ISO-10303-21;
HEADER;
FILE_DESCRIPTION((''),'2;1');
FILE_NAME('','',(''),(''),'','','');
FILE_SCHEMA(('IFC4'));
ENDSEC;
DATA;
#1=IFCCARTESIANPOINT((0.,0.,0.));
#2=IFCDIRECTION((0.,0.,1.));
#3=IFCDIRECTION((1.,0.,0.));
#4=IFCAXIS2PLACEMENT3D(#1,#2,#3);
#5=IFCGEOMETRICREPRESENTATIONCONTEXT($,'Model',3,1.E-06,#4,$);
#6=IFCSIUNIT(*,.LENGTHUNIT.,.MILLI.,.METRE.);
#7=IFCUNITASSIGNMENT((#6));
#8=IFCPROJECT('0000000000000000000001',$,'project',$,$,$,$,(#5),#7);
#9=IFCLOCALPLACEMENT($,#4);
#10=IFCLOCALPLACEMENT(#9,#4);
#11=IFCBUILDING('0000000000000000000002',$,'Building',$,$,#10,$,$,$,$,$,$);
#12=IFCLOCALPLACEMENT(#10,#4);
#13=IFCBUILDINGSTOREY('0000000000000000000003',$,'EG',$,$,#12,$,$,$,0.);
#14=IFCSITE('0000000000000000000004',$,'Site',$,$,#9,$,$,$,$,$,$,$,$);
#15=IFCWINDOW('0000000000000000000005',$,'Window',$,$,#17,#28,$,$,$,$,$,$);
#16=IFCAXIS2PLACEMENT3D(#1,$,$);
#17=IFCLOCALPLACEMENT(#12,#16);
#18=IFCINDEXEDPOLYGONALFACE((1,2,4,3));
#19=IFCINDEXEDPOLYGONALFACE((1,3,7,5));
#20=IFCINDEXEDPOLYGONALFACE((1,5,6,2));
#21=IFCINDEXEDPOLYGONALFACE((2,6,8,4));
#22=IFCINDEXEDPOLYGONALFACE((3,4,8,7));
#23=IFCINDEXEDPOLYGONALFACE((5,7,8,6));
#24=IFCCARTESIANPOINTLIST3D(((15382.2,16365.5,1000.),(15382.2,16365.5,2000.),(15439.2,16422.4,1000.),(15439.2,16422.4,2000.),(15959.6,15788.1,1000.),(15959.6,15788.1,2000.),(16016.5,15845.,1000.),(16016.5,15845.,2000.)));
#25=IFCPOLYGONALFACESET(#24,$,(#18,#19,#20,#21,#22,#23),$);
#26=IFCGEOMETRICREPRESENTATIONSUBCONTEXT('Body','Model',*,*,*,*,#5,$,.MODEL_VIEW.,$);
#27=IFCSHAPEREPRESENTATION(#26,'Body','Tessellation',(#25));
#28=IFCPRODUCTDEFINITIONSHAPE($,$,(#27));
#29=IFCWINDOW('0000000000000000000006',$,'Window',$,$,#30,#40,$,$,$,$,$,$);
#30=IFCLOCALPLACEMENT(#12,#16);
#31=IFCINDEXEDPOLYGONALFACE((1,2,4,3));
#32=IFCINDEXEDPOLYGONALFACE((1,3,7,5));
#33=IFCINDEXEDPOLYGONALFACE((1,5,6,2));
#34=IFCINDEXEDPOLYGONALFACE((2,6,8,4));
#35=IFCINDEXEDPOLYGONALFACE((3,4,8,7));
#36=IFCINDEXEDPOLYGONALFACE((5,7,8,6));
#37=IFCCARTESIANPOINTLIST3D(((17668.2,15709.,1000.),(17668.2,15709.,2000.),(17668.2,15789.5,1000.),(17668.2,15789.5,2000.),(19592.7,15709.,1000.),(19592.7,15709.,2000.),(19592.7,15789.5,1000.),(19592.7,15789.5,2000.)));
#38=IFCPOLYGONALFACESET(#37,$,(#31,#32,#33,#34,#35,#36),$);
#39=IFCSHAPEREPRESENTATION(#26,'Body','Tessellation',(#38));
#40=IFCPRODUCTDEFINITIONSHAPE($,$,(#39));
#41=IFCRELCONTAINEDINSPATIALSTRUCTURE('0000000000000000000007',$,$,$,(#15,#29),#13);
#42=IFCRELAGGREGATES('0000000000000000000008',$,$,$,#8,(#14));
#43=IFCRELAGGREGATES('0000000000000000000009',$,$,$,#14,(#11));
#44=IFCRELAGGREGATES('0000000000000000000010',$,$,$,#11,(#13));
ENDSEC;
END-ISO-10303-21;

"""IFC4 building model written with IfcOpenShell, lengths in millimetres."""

from ifc_helpers import new_model, si_unit, frame, origin_with_axes, place, context, subcontext, project, spatial, rectangle, extrude, element, save


model = new_model("IFC4")

# Units and contexts
model_context = context("Model", 3, precision=1e-06, world=origin_with_axes())
body_context = subcontext(model_context, "Body", "Model", "MODEL_VIEW")
ifc_project = project(units=[si_unit("LENGTHUNIT", "METRE", prefix="MILLI")], contexts=[model_context])

# Site, building, storey
site_placement = place(None, origin_with_axes())
site = spatial("IfcSite", under=ifc_project, at=site_placement, Name="Site")
building_placement = place(site_placement, origin_with_axes())
building = spatial("IfcBuilding", under=site, at=building_placement, Name="Building")
storey_placement = place(building_placement, origin_with_axes())
storey = spatial("IfcBuildingStorey", under=building, at=storey_placement, Name="EG", Elevation=0.0)

# Windows
window_1_placement = place(storey_placement, origin_with_axes())
element("IfcWindow", 1, at=window_1_placement, inside=storey, Name="Window", context=body_context, shape_type="SweptSolid", body=[
    extrude(rectangle(XDim=816.5, YDim=80.5), frame((15699.4, 16105.2, 1000.0), z_axis=(0.0, 0.0, 1.0), x_axis=(-0.707107, 0.707107, 0.0)), (0.0, 0.0, 1.0), 1000.0),
])
window_2_placement = place(storey_placement, origin_with_axes())
element("IfcWindow", 2, at=window_2_placement, inside=storey, Name="Window", context=body_context, shape_type="SweptSolid", body=[
    extrude(rectangle(XDim=1924.6, YDim=80.5), frame((18630.5, 15749.3, 1000.0), z_axis=(0.0, 0.0, 1.0), x_axis=(1.0, 0.0, 0.0)), (0.0, 0.0, 1.0), 1000.0),
])

save(model, "model.ifc")
